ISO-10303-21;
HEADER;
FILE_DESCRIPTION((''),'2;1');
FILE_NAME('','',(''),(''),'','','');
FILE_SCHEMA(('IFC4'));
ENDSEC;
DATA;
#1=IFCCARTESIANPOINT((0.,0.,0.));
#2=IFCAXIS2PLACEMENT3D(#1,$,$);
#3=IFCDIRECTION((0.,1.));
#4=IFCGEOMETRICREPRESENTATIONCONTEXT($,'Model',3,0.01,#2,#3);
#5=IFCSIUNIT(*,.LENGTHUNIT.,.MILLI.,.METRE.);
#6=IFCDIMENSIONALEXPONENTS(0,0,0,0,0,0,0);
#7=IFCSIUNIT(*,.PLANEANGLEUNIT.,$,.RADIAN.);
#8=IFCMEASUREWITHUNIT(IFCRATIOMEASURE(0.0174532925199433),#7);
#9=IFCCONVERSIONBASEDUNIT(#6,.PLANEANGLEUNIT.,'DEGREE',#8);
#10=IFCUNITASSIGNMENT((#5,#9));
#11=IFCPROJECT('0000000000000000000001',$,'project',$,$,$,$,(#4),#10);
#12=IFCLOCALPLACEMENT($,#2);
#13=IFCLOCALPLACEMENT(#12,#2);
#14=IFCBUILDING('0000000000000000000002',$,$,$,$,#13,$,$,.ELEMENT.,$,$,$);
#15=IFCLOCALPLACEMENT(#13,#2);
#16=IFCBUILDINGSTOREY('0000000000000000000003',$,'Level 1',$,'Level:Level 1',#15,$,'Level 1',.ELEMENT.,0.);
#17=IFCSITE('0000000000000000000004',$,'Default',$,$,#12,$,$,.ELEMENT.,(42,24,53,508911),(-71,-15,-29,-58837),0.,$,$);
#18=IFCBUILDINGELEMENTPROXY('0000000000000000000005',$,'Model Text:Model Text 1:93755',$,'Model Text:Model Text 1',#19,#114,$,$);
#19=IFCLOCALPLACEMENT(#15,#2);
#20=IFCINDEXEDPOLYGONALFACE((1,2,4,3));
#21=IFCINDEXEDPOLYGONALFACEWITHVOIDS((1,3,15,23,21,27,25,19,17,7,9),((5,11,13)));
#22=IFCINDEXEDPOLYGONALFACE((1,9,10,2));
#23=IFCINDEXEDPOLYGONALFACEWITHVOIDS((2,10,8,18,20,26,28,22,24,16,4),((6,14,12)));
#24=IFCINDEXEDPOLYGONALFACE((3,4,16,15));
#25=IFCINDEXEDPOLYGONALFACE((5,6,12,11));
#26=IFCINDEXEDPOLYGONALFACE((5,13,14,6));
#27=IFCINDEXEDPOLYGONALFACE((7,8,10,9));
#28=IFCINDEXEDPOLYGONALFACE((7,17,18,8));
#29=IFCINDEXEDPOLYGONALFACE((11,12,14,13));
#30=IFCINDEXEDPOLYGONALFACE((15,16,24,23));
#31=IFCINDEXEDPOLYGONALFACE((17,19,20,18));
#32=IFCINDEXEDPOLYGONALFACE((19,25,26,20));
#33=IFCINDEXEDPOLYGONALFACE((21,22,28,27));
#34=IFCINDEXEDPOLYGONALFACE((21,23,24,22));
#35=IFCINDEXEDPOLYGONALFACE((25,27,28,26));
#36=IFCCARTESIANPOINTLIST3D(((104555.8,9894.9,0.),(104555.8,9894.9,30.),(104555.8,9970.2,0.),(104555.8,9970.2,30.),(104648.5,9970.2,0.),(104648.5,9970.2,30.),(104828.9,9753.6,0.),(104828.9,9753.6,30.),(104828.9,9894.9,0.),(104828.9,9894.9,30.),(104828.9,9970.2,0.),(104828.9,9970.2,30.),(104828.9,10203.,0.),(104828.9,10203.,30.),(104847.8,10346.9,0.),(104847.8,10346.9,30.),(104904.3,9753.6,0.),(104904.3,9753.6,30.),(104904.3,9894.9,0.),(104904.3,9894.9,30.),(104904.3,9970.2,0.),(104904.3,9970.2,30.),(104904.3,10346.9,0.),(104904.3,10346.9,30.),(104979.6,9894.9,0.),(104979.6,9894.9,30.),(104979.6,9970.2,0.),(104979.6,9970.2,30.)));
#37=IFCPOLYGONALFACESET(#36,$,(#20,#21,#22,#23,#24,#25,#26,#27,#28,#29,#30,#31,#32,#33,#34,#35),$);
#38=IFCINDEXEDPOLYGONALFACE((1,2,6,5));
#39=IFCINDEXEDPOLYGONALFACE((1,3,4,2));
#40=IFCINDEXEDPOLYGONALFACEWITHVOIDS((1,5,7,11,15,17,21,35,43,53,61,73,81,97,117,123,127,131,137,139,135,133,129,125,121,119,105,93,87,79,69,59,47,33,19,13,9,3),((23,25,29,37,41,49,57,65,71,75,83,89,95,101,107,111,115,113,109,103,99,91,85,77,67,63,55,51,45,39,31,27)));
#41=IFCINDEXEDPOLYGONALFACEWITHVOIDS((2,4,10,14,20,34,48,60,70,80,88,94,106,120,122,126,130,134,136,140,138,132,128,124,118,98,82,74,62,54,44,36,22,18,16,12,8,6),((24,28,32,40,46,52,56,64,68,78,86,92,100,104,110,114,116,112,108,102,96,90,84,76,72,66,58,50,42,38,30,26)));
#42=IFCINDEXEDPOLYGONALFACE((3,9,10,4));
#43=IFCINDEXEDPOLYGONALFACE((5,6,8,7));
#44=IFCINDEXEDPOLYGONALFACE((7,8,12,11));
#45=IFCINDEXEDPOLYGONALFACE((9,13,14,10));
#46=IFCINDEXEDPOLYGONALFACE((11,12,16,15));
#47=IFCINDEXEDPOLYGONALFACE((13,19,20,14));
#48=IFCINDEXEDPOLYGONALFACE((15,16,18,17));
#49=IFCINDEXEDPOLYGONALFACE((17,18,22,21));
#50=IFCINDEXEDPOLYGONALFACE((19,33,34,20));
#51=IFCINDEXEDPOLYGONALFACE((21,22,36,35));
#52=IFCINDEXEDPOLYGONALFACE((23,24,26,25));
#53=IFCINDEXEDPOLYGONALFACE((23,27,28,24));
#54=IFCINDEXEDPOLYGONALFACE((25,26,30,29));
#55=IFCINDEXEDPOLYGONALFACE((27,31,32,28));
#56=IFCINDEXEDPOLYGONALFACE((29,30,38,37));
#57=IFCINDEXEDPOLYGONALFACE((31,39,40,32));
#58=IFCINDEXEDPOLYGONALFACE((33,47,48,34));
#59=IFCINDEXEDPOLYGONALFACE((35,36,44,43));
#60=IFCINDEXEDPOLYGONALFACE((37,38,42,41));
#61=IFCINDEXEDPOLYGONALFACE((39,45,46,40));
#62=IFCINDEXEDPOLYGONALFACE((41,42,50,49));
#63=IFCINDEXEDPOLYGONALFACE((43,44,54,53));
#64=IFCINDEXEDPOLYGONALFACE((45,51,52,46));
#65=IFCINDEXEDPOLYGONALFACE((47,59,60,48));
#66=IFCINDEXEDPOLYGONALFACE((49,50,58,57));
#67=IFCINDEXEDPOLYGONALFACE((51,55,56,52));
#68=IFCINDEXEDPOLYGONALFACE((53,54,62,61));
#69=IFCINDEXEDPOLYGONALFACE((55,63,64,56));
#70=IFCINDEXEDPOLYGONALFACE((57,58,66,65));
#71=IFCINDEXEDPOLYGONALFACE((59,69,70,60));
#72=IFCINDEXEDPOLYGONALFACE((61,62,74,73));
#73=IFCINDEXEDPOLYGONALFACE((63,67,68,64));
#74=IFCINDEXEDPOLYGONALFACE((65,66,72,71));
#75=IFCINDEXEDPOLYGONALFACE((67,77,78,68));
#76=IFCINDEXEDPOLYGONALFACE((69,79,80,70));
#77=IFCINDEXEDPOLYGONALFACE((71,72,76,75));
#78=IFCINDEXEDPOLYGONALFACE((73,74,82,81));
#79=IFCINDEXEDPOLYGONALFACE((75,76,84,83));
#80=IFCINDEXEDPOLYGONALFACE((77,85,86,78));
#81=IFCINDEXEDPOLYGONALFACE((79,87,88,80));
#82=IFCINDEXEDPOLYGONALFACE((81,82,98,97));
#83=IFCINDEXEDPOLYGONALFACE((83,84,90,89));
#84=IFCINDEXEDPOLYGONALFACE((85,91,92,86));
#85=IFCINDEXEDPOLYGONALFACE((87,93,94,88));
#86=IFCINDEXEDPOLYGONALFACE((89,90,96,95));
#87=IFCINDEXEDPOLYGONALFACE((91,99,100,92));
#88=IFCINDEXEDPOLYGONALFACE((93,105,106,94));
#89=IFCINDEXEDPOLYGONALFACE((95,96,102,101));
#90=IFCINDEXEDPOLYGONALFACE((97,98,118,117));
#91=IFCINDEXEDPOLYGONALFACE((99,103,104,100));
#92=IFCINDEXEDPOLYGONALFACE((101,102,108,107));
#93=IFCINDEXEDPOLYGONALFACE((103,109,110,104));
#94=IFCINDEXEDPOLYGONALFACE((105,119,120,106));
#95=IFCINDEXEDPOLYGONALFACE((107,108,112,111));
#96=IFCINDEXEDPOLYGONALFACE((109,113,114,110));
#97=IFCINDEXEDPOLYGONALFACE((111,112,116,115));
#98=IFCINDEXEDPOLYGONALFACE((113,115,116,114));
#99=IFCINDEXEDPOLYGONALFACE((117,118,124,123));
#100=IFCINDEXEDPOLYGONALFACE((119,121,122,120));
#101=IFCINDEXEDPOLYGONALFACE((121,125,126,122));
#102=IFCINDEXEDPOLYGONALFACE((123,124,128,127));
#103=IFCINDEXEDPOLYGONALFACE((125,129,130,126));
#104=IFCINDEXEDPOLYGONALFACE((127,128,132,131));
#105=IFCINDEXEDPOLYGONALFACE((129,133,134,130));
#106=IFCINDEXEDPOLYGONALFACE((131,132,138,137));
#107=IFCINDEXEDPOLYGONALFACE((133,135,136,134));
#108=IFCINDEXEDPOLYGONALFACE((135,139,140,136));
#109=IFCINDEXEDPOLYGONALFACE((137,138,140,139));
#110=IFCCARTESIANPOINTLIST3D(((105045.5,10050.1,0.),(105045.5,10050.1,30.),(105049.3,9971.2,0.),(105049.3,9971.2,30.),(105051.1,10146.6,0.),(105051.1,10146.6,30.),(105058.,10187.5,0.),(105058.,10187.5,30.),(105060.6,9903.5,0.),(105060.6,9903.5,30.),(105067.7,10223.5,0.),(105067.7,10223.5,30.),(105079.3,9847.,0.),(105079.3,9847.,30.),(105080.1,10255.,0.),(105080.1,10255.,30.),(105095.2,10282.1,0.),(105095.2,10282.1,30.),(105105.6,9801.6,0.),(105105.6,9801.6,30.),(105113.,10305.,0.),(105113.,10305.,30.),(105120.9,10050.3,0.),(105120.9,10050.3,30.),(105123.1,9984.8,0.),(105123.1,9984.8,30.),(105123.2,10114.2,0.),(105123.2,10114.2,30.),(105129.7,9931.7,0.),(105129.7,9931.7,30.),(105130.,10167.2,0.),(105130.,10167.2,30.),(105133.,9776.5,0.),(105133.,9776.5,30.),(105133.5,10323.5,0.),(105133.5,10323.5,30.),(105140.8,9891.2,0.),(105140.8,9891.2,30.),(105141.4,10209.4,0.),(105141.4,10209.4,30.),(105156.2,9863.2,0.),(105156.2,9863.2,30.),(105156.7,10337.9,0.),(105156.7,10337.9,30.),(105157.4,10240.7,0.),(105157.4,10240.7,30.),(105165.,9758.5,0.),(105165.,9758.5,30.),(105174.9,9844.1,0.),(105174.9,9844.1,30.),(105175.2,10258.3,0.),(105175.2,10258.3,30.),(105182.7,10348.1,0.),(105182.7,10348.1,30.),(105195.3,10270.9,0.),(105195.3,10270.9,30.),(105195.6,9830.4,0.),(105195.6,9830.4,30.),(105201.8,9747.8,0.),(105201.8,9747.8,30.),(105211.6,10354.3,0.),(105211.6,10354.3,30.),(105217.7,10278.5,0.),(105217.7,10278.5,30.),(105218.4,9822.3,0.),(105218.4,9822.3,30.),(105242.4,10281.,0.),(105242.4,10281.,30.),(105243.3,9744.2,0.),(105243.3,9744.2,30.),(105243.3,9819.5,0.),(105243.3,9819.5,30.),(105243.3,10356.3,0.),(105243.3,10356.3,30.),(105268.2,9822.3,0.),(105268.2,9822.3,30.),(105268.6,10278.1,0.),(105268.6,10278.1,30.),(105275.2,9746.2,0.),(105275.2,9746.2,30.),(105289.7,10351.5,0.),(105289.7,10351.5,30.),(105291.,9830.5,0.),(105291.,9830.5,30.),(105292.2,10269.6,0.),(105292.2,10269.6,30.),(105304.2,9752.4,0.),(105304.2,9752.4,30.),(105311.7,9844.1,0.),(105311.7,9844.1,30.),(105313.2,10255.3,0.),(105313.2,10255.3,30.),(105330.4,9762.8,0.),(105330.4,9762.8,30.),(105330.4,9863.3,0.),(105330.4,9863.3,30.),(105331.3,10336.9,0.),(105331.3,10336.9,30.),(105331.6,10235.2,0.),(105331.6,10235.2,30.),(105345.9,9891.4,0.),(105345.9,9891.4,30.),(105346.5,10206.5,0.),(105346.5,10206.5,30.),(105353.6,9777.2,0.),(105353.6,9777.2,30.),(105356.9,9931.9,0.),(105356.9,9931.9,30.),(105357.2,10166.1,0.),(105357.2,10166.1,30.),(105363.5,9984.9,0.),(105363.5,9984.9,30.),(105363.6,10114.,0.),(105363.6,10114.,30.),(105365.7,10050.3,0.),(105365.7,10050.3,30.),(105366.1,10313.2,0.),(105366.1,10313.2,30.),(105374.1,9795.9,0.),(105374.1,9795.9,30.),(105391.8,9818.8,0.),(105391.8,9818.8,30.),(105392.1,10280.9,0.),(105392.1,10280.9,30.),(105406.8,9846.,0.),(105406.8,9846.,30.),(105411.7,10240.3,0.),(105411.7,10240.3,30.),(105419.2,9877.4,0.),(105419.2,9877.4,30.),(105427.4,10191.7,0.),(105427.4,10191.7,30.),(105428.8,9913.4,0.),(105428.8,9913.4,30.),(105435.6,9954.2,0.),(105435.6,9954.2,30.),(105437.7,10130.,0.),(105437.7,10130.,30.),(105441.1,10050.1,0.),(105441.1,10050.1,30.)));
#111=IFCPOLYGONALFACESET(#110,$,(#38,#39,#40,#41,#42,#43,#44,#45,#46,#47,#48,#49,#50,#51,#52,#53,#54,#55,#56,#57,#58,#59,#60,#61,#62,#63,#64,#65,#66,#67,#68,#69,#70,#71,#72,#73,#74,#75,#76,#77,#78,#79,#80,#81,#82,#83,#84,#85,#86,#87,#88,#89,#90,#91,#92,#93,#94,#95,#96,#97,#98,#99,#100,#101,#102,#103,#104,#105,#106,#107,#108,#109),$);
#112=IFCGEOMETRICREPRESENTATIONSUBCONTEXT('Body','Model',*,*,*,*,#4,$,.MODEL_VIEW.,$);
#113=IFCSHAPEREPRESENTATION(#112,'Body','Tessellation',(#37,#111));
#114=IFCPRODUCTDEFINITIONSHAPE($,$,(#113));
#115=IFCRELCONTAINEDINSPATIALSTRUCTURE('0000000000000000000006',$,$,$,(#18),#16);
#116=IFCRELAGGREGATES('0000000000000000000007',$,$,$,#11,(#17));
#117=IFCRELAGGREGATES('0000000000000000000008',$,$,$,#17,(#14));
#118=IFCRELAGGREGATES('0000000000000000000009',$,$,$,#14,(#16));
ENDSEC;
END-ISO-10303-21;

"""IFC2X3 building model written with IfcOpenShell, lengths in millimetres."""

from ifc_helpers import new_model, entity, si_unit, converted_unit, direction, frame, origin, place, context, subcontext, project, spatial, polyline, outline, extrude, element, save


model = new_model("IFC2X3")

# Units and contexts
model_context = context("Model", 3, precision=0.01, world=origin(), true_north=direction((0.0, 1.0)))
body_context = subcontext(model_context, "Body", "Model", "MODEL_VIEW")
ifc_project = project(units=[si_unit("LENGTHUNIT", "METRE", prefix="MILLI"), converted_unit("PLANEANGLEUNIT", "DEGREE", entity("IfcRatioMeasure", 0.0174532925199433), si_unit("PLANEANGLEUNIT", "RADIAN"), dimensions=[0, 0, 0, 0, 0, 0, 0])], contexts=[model_context])

# Site, building, storey
site_placement = place(None, origin())
site = spatial("IfcSite", under=ifc_project, at=site_placement, Name="Default", CompositionType="ELEMENT", RefLatitude=(42, 24, 53, 508911), RefLongitude=(-71, -15, -29, -58837), RefElevation=0.0)
building_placement = place(site_placement, origin())
building = spatial("IfcBuilding", under=site, at=building_placement, CompositionType="ELEMENT")
storey_placement = place(building_placement, origin())
storey = spatial("IfcBuildingStorey", under=building, at=storey_placement, Name="Level 1", ObjectType="Level:Level 1", LongName="Level 1", CompositionType="ELEMENT", Elevation=0.0)

# Building element proxy
proxy_1_placement = place(storey_placement, origin())
element("IfcBuildingElementProxy", 1, at=proxy_1_placement, inside=storey, Name="Model Text:Model Text 1:93755", ObjectType="Model Text:Model Text 1", context=body_context, shape_type="SweptSolid", body=[
    extrude(outline(polyline([(-6.8, -218.3), (68.5, -218.3), (68.5, -77.1), (143.8, -77.1), (143.8, -1.7), (68.5, -1.7), (68.5, 375.0), (12.0, 375.0), (-280.0, -1.7), (-280.0, -77.1), (-6.8, -77.1), (-6.8, -218.3)]), holes=[polyline([(-6.8, -1.7), (-187.3, -1.7), (-6.8, 231.1), (-6.8, -1.7)])]), frame((104835.8, 9971.9, 0.0)), (0.0, 0.0, 1.0), 30.0),
    extrude(outline(polyline([(-10.6, -198.7), (68.3, -198.7), (136.5, -190.7), (193.9, -174.7), (240.5, -150.6), (266.9, -124.4), (286.3, -93.2), (298.8, -57.0), (304.3, -15.7), (303.8, 16.2), (299.0, 45.5), (289.9, 72.1), (276.6, 96.0), (258.9, 117.3), (236.9, 136.2), (210.4, 152.5), (179.6, 166.3), (144.1, 177.6), (103.7, 186.3), (8.2, 196.4), (-71.8, 196.7), (-134.0, 189.4), (-183.3, 176.1), (-224.7, 158.4), (-258.2, 133.9), (-283.5, 100.3), (-300.1, 59.5), (-307.1, 13.4), (-306.6, -18.4), (-301.8, -47.5), (-292.8, -74.0), (-279.6, -97.9), (-262.0, -119.2), (-240.0, -138.1), (-213.6, -154.5), (-182.8, -168.4), (-147.3, -179.8), (-106.7, -188.6), (-10.6, -198.7)]), holes=[polyline([(-7.2, -123.5), (-71.0, -118.2), (-123.6, -108.8), (-165.2, -95.4), (-195.7, -78.0), (-212.4, -59.4), (-224.1, -38.7), (-230.6, -15.9), (-231.9, 8.9), (-227.8, 35.0), (-218.1, 58.1), (-202.8, 78.4), (-182.0, 95.8), (-152.6, 109.4), (-111.7, 118.1), (-59.4, 122.0), (4.4, 121.1), (69.6, 115.8), (122.2, 106.7), (162.2, 93.7), (189.5, 77.0), (207.7, 57.4), (220.4, 36.0), (227.5, 12.8), (229.1, -12.1), (225.2, -36.8), (215.9, -59.2), (201.3, -79.3), (181.4, -97.1), (152.6, -111.2), (111.6, -120.3), (58.3, -124.4), (-7.2, -123.5)])]), frame((105244.6, 10048.9, 0.0), z_axis=(0.0, 0.0, 1.0), x_axis=(0.047515, -0.998871, 0.0)), (0.0, 0.0, 1.0), 30.0),
])

save(model, "model.ifc")
